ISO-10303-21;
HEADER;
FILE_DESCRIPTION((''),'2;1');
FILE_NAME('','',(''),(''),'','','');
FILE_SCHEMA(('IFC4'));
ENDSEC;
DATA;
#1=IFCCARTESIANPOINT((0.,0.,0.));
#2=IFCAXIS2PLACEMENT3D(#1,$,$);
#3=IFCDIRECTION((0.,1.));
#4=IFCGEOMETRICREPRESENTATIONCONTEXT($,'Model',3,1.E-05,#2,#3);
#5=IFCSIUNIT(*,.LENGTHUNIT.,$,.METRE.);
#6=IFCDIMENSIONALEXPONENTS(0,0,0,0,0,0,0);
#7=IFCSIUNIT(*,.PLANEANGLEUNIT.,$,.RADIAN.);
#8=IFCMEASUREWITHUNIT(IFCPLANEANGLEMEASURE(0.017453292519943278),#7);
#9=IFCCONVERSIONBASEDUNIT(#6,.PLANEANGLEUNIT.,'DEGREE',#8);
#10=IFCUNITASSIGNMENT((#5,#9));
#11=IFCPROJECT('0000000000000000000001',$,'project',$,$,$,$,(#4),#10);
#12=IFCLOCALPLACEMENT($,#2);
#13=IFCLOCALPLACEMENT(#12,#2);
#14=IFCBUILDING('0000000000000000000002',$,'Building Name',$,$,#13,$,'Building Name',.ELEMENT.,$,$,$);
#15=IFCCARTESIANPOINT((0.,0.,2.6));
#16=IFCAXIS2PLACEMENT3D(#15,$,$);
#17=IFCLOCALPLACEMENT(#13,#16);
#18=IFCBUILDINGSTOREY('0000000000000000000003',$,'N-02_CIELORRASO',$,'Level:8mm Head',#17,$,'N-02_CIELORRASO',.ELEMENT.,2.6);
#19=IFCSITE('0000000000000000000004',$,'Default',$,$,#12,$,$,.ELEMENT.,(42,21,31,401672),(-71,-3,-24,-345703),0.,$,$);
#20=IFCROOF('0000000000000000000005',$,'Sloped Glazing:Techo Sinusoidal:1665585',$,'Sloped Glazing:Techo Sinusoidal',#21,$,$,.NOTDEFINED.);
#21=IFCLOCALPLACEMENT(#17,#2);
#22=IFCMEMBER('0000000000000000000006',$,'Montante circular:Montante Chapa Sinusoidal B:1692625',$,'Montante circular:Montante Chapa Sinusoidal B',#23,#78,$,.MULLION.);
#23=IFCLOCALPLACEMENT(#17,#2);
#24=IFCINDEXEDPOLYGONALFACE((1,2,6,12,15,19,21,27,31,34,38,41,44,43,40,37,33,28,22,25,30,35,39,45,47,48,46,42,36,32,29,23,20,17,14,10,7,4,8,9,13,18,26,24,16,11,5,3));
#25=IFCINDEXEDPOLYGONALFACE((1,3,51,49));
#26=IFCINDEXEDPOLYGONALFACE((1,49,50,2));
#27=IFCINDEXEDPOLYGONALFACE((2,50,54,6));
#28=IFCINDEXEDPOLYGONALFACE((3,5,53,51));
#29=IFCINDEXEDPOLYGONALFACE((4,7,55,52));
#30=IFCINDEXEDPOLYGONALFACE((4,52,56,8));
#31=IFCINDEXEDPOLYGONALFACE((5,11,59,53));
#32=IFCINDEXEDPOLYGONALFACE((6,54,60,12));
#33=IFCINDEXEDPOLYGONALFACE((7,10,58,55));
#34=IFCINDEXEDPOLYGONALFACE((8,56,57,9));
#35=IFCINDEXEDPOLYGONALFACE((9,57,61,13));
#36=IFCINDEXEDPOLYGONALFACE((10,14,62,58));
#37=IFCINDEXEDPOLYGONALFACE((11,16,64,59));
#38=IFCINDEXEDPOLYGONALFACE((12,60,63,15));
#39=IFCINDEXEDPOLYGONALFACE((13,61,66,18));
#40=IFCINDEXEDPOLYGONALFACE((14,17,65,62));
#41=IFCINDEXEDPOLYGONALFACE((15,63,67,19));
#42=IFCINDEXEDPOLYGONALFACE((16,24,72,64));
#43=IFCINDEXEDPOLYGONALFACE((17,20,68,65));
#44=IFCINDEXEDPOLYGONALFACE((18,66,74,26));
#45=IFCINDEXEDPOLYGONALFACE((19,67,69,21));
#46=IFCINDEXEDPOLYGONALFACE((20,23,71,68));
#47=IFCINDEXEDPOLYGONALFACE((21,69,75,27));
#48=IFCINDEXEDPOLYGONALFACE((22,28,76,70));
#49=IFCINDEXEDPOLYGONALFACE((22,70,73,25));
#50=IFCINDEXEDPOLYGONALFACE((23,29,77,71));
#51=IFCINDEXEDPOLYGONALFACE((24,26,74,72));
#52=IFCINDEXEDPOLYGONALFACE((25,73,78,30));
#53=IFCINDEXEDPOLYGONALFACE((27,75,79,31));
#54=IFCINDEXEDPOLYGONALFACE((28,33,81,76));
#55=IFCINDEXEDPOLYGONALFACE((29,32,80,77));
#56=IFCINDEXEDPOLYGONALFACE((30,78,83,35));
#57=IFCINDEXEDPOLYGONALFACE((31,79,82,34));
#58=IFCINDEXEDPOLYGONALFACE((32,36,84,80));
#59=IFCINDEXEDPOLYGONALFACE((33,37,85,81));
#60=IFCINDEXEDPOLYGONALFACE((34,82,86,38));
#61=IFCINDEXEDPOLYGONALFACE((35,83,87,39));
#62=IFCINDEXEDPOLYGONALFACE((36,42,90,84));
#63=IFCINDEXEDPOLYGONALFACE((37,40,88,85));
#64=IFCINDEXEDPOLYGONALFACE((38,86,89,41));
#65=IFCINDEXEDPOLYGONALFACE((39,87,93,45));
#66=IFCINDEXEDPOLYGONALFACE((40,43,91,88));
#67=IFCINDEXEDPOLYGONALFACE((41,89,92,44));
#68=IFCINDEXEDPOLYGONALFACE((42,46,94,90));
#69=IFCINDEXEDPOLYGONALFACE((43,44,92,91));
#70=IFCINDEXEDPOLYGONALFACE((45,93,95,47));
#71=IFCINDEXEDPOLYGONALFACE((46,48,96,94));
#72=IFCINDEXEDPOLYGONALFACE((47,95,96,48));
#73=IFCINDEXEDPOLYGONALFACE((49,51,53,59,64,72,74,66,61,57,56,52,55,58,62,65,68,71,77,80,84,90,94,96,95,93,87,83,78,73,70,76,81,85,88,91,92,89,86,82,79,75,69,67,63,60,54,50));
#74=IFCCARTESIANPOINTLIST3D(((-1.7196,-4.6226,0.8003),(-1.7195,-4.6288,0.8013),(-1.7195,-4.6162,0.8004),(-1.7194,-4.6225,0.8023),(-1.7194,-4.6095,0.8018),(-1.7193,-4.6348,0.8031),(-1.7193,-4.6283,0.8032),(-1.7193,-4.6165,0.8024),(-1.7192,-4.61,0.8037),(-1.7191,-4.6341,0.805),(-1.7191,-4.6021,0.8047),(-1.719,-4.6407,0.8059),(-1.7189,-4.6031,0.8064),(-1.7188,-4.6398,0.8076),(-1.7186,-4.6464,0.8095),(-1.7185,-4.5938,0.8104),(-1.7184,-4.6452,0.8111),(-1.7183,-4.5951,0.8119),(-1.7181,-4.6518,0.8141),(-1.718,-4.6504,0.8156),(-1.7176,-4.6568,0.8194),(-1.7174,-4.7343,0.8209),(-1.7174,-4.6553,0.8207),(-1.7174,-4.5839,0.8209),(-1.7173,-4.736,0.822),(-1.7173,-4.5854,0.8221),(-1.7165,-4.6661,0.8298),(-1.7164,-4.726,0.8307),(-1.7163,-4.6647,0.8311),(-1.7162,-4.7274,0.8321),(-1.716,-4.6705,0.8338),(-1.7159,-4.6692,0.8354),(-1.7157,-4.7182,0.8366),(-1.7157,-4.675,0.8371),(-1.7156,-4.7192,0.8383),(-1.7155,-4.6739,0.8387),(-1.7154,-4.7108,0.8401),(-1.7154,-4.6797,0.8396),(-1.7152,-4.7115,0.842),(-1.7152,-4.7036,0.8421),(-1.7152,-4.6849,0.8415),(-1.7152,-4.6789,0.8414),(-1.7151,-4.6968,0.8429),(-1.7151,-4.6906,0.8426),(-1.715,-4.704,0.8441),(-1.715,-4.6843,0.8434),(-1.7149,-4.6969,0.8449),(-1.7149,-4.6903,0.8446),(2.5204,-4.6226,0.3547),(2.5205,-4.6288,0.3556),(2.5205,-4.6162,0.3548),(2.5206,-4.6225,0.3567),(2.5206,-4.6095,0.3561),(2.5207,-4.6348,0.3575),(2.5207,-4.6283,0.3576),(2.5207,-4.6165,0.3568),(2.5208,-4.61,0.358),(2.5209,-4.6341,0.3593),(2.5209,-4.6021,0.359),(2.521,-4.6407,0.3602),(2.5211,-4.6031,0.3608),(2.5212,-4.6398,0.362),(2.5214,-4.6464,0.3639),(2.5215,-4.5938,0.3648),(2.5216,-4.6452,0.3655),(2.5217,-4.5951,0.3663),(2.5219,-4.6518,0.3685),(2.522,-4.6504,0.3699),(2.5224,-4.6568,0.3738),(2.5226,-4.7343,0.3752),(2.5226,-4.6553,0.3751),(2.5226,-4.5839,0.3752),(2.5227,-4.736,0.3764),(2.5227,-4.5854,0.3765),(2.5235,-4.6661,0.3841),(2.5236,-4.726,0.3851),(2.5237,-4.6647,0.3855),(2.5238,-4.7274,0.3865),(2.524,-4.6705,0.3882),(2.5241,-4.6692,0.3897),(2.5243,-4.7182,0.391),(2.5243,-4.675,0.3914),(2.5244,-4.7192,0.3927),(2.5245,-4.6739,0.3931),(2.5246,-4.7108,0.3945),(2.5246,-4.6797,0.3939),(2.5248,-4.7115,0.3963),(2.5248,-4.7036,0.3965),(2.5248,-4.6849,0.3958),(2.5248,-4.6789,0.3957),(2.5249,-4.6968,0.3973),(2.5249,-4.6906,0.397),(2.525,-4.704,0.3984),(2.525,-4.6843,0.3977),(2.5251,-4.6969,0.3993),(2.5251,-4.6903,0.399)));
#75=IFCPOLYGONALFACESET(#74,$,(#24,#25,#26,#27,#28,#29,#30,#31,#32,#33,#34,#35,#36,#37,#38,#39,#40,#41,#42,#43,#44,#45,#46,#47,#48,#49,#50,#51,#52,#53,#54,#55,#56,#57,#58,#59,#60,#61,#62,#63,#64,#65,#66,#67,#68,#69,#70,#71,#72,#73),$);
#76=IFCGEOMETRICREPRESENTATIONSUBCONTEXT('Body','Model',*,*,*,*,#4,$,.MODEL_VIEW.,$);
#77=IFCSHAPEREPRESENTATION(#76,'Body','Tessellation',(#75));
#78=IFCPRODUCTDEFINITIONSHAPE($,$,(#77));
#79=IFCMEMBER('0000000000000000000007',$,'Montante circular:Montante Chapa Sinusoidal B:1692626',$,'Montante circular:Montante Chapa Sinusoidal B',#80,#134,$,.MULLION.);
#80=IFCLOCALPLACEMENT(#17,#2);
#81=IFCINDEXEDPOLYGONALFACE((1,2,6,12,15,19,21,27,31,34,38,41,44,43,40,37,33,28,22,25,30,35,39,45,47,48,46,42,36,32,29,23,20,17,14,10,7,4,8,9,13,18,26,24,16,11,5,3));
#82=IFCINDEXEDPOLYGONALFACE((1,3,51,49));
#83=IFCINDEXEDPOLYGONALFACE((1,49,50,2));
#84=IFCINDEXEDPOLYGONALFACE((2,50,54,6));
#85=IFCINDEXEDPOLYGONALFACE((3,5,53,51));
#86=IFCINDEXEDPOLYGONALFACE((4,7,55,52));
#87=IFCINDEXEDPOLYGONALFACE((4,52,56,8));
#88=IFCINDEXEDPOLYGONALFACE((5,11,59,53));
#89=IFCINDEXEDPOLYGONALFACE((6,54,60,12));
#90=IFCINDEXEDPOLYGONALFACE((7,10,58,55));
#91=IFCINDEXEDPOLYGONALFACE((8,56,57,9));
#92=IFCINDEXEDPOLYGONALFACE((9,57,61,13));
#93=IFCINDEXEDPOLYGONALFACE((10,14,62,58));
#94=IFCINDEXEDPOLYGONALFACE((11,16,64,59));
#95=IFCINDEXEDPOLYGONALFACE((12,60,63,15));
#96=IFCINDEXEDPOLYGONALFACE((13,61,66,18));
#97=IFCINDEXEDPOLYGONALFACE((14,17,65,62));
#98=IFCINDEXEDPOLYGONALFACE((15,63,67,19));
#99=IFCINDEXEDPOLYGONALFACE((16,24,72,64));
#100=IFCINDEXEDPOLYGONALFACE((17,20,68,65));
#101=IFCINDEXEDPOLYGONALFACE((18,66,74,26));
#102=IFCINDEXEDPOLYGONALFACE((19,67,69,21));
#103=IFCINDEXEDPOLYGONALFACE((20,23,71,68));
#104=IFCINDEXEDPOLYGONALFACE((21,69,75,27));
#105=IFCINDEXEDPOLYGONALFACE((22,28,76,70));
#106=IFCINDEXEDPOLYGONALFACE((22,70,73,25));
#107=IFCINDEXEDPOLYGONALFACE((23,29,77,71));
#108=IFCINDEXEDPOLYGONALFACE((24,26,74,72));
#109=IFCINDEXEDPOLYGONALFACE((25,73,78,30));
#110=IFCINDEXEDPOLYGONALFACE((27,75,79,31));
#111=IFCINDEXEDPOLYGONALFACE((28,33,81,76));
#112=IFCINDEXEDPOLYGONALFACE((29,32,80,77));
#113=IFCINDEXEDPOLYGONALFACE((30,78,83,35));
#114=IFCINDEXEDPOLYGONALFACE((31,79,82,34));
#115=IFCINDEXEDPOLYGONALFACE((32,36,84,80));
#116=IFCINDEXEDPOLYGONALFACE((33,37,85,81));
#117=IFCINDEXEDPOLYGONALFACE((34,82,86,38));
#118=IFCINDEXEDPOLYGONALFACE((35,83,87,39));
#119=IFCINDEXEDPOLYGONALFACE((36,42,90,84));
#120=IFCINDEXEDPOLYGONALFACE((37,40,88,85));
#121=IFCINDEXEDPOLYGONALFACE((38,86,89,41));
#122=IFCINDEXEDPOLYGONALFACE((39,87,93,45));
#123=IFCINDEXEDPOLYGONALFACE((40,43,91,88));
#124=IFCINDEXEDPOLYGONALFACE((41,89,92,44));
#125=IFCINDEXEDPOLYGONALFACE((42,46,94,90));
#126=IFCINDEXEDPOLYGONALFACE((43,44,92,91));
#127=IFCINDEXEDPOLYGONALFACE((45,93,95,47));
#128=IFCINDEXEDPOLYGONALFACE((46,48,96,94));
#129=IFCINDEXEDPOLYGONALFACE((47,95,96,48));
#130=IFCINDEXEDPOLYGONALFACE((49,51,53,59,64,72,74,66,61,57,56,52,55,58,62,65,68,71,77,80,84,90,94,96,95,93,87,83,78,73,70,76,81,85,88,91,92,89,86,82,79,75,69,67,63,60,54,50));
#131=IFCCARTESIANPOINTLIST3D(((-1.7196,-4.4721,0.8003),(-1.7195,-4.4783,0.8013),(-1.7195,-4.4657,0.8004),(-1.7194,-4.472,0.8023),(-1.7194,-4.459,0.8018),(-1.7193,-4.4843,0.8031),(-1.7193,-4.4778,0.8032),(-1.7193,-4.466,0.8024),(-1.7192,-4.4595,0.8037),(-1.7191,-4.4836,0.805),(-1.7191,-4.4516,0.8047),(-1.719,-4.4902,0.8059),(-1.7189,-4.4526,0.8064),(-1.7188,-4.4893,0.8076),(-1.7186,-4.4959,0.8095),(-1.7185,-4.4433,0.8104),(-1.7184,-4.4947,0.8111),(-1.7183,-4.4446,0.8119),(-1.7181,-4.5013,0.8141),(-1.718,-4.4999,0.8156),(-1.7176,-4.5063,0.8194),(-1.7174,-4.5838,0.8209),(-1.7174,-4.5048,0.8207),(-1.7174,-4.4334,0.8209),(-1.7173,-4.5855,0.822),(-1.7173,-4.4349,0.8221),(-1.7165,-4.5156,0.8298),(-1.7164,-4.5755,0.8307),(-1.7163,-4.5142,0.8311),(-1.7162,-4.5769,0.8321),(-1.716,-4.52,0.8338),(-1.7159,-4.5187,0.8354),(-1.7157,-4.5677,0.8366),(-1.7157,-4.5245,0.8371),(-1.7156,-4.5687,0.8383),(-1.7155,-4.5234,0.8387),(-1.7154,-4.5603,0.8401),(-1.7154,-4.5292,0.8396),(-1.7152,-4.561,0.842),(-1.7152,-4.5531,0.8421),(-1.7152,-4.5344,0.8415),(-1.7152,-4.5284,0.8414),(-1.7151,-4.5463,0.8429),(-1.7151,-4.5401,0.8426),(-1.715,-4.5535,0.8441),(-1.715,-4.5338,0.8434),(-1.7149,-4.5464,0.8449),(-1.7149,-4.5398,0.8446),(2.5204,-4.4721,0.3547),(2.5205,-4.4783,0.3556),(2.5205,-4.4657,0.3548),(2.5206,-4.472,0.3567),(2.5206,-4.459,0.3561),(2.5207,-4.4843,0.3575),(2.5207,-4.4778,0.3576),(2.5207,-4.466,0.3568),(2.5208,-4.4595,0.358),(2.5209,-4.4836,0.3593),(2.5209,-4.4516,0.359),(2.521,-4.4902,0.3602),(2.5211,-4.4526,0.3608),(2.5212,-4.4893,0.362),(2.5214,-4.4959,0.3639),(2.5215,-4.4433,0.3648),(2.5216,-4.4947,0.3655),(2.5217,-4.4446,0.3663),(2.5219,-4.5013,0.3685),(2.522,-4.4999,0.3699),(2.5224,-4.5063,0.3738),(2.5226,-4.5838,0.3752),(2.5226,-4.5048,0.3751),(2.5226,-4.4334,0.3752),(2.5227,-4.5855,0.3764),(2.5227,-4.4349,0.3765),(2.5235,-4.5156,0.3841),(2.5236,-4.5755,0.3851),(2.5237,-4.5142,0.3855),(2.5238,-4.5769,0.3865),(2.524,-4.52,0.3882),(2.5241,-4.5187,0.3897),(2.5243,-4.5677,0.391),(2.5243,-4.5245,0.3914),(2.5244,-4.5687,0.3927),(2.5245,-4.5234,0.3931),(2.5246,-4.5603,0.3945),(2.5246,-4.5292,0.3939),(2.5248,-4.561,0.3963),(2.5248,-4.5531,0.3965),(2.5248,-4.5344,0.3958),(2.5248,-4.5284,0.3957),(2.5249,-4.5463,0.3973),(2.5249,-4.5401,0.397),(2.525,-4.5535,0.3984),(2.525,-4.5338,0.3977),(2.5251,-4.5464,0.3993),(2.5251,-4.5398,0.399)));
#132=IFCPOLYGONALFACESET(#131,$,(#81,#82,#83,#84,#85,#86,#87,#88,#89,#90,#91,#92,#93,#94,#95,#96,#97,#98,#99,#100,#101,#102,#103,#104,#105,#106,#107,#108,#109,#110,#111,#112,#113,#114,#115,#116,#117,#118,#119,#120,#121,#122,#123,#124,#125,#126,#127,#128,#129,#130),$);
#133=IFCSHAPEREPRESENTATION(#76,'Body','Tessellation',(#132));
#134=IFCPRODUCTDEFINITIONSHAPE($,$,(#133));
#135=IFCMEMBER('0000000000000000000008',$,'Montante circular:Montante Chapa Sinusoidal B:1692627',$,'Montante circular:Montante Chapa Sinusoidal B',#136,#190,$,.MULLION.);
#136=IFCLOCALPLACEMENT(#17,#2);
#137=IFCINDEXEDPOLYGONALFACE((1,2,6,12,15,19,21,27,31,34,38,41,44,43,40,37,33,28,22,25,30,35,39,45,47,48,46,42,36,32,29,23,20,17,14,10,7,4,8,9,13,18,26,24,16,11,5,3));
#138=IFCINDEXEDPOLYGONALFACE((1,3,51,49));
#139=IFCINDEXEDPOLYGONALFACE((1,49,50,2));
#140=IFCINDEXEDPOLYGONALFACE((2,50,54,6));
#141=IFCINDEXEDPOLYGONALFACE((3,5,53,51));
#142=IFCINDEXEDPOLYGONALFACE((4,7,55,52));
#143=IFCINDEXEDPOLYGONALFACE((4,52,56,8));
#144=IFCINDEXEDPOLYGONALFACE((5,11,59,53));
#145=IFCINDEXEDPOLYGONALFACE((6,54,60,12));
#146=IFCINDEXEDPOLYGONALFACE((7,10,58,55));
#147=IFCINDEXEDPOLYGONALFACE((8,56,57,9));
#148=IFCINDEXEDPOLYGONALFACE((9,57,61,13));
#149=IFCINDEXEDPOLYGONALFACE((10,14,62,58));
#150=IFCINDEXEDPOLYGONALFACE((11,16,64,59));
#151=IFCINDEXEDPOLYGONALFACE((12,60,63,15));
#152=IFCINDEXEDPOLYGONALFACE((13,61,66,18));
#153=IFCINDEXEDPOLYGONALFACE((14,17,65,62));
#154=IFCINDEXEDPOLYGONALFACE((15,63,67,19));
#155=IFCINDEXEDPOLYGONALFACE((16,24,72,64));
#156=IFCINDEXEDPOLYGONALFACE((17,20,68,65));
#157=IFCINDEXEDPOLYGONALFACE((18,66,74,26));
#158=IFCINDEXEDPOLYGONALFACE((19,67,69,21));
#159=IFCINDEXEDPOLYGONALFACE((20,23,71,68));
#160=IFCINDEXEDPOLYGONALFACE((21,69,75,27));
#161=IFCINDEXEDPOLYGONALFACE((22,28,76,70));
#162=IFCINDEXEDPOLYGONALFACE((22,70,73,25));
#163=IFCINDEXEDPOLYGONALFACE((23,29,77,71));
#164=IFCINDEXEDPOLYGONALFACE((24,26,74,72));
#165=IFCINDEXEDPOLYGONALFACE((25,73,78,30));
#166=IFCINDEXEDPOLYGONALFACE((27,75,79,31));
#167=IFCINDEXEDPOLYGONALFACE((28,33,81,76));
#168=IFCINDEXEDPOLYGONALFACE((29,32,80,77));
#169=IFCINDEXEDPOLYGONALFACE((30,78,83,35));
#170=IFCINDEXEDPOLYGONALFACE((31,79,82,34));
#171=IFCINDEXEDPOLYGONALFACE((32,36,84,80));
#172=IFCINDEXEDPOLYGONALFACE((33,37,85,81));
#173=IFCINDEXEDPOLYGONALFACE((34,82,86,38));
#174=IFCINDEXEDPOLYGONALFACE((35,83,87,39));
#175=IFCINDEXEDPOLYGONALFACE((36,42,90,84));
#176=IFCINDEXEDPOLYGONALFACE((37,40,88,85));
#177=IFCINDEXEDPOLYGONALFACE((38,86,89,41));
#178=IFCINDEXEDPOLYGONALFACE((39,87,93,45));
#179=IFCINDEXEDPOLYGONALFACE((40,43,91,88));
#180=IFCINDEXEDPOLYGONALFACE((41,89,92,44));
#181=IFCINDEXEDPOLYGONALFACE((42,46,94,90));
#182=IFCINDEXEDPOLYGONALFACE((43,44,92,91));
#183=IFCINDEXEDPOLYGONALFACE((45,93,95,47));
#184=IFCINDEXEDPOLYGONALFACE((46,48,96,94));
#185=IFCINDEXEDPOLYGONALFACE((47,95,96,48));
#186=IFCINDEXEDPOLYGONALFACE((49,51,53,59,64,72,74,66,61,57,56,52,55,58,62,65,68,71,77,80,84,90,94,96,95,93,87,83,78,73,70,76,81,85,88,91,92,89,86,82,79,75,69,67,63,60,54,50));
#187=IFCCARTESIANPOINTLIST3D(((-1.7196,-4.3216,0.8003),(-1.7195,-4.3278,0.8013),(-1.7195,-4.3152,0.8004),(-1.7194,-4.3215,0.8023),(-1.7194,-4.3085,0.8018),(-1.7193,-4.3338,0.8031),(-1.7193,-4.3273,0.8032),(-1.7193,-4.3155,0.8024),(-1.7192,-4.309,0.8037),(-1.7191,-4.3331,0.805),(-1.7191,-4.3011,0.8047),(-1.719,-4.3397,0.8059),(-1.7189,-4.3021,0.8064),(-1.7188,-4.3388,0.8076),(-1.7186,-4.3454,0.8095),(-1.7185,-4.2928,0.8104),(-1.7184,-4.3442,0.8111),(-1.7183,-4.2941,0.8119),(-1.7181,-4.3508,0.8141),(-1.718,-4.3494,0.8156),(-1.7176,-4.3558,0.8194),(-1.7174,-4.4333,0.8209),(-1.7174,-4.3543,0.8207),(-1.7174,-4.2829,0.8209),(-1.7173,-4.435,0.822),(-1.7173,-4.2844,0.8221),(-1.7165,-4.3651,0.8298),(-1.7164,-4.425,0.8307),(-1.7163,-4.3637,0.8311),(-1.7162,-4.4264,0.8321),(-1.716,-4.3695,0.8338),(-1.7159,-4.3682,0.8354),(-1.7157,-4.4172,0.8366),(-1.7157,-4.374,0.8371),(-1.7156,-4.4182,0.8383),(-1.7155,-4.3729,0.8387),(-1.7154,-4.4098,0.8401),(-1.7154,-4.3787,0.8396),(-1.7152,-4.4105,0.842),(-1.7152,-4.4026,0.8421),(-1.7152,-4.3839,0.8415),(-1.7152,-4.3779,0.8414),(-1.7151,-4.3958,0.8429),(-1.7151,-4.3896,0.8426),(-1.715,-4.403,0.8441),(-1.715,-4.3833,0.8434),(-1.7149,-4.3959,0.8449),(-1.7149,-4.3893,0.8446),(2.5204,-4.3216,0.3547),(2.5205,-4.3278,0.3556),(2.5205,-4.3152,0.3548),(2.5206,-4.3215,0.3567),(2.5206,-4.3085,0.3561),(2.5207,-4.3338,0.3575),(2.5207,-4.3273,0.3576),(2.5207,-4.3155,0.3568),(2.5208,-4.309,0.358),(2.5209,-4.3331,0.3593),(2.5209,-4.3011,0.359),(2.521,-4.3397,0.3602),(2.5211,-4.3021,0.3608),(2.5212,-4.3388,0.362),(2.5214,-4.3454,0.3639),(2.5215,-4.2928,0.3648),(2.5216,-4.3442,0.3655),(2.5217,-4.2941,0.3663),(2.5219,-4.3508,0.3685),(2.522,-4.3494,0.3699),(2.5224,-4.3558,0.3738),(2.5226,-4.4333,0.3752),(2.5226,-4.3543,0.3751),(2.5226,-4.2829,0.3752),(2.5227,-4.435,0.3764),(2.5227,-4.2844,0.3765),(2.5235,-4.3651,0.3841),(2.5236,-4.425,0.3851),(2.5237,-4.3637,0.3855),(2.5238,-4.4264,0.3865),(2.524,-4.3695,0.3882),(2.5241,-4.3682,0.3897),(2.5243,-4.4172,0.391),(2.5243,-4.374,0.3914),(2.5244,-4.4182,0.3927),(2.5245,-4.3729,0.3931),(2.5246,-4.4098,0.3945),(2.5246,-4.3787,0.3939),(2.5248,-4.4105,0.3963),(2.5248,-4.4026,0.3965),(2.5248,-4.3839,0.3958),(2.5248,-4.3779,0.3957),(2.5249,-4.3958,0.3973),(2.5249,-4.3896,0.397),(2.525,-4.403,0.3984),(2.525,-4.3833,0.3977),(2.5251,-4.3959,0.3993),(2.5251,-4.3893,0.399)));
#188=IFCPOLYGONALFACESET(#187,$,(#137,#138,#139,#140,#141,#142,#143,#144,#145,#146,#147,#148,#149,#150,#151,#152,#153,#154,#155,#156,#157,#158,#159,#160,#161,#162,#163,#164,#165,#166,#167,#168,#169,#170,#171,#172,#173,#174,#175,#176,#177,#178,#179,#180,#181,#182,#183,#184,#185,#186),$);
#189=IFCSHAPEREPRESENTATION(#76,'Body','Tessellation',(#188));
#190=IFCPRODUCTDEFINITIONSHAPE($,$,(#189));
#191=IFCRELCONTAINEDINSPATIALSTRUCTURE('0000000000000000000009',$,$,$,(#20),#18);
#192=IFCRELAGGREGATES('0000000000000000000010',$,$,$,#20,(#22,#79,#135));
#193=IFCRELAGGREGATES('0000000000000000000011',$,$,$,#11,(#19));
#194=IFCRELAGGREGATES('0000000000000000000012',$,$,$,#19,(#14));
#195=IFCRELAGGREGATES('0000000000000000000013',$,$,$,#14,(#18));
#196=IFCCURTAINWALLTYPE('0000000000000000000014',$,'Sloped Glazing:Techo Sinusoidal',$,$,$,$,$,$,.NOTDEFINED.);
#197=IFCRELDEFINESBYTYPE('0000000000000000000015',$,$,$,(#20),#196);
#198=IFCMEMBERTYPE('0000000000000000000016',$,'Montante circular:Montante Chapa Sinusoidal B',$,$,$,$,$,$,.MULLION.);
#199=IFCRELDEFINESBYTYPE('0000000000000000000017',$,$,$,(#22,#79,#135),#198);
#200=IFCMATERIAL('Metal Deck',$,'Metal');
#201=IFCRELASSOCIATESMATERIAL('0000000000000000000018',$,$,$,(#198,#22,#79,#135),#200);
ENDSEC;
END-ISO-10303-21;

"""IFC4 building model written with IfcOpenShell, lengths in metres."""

from ifc_helpers import new_model, entity, si_unit, converted_unit, direction, frame, origin, place, context, subcontext, project, spatial, indexed_curve, outline, extrude, source, transform, mapped, material, type_object, type_shapes, element, aggregate, save


model = new_model("IFC4")

# Units and contexts
model_context = context("Model", 3, precision=1e-05, world=origin(), true_north=direction((0.0, 1.0)))
body_context = subcontext(model_context, "Body", "Model", "MODEL_VIEW")
ifc_project = project(units=[si_unit("LENGTHUNIT", "METRE"), converted_unit("PLANEANGLEUNIT", "DEGREE", entity("IfcPlaneAngleMeasure", 0.017453292519943278), si_unit("PLANEANGLEUNIT", "RADIAN"), dimensions=[0, 0, 0, 0, 0, 0, 0])], contexts=[model_context])

# Site, building, storey
site_placement = place(None, origin())
site = spatial("IfcSite", under=ifc_project, at=site_placement, Name="Default", CompositionType="ELEMENT", RefLatitude=(42, 21, 31, 401672), RefLongitude=(-71, -3, -24, -345703), RefElevation=0.0)
building_placement = place(site_placement, origin())
building = spatial("IfcBuilding", under=site, at=building_placement, Name="Building Name", LongName="Building Name", CompositionType="ELEMENT")
storey_placement = place(building_placement, frame((0.0, 0.0, 2.6)))
storey = spatial("IfcBuildingStorey", under=building, at=storey_placement, Name="N-02_CIELORRASO", ObjectType="Level:8mm Head", LongName="N-02_CIELORRASO", CompositionType="ELEMENT", Elevation=2.6)

# Roof, members
curtain_wall_type = type_object("IfcCurtainWallType", Name="Sloped Glazing:Techo Sinusoidal", PredefinedType="NOTDEFINED")
roof_1_placement = place(storey_placement, frame((0.0, 0.0, -2.6)))
roof_1 = element("IfcRoof", 1, at=roof_1_placement, inside=storey, type_object=curtain_wall_type, Name="Sloped Glazing:Techo Sinusoidal:1665585", ObjectType="Sloped Glazing:Techo Sinusoidal", PredefinedType="NOTDEFINED")
ifc_material = material(Name="Metal Deck", Category="Metal")
member_type_1 = type_object("IfcMemberType", Name="Montante circular:Montante Chapa Sinusoidal B", PredefinedType="MULLION", material=ifc_material)
shared_shape_1 = source(origin(), body_context, "Body", "SweptSolid", [
    extrude(outline(indexed_curve([(0.0595, -0.0443), (0.0615, -0.0443), (0.0603, -0.031), (0.0572, -0.0213), (0.053, -0.0138), (0.0481, -0.0078), (0.0427, -0.003), (0.0372, 0.0005), (0.0315, 0.0029), (0.0259, 0.0044), (0.0203, 0.0051), (0.0146, 0.005), (0.0084, 0.0041), (-0.0053, 0.0009), (-0.0123, -0.0005), (-0.0191, -0.0012), (-0.0256, -0.001), (-0.0317, 0.0001), (-0.0375, 0.0019), (-0.0428, 0.0046), (-0.0477, 0.0081), (-0.0522, 0.0128), (-0.0563, 0.0191), (-0.0597, 0.0282), (-0.0617, 0.0421), (-0.0637, 0.042), (-0.0616, 0.0277), (-0.0581, 0.0182), (-0.0537, 0.0116), (-0.049, 0.0066), (-0.0438, 0.0028), (-0.0382, 0.0001), (-0.0322, -0.0019), (-0.0258, -0.003), (-0.019, -0.0032), (-0.012, -0.0025), (-0.0048, -0.0011), (0.0088, 0.0021), (0.0147, 0.003), (0.0202, 0.0031), (0.0255, 0.0024), (0.0309, 0.001), (0.0362, -0.0013), (0.0415, -0.0046), (0.0466, -0.0092), (0.0513, -0.0149), (0.0554, -0.0221), (0.0584, -0.0314), (0.0595, -0.0443)], self_intersect=False)), frame((-0.007, 0.0228, -4.2634), z_axis=(0.0, 0.0, 1.0), x_axis=(-0.819152, -0.573576, 0.0)), (0.0, 0.0, 1.0), 4.2634),
])
type_shapes(member_type_1, [shared_shape_1])
member_1_placement = place(roof_1_placement, frame((-1.7148, -4.6531, 3.4456), z_axis=(-0.994522, 0.0, 0.104528), x_axis=(0.0, 1.0, 0.0)))
member_1 = element("IfcMember", 2, at=member_1_placement, type_object=member_type_1, material=ifc_material, Name="Montante circular:Montante Chapa Sinusoidal B:1692625", ObjectType="Montante circular:Montante Chapa Sinusoidal B", PredefinedType="MULLION", context=body_context, shape_type="MappedRepresentation", body=[
    mapped(shared_shape_1, transform((0.0, 0.0, 0.0), scale=1.0)),
])
member_2_placement = place(roof_1_placement, frame((-1.7148, -4.5026, 3.4456), z_axis=(-0.994522, 0.0, 0.104528), x_axis=(0.0, 1.0, 0.0)))
member_2 = element("IfcMember", 3, at=member_2_placement, type_object=member_type_1, material=ifc_material, Name="Montante circular:Montante Chapa Sinusoidal B:1692626", ObjectType="Montante circular:Montante Chapa Sinusoidal B", PredefinedType="MULLION", context=body_context, shape_type="MappedRepresentation", body=[
    mapped(shared_shape_1, transform((0.0, 0.0, 0.0), scale=1.0)),
])
member_3_placement = place(roof_1_placement, frame((-1.7148, -4.3521, 3.4456), z_axis=(-0.994522, 0.0, 0.104528), x_axis=(0.0, 1.0, 0.0)))
member_3 = element("IfcMember", 4, at=member_3_placement, type_object=member_type_1, material=ifc_material, Name="Montante circular:Montante Chapa Sinusoidal B:1692627", ObjectType="Montante circular:Montante Chapa Sinusoidal B", PredefinedType="MULLION", context=body_context, shape_type="MappedRepresentation", body=[
    mapped(shared_shape_1, transform((0.0, 0.0, 0.0), scale=1.0)),
])
aggregate(roof_1, [member_1, member_2, member_3])

save(model, "model.ifc")
